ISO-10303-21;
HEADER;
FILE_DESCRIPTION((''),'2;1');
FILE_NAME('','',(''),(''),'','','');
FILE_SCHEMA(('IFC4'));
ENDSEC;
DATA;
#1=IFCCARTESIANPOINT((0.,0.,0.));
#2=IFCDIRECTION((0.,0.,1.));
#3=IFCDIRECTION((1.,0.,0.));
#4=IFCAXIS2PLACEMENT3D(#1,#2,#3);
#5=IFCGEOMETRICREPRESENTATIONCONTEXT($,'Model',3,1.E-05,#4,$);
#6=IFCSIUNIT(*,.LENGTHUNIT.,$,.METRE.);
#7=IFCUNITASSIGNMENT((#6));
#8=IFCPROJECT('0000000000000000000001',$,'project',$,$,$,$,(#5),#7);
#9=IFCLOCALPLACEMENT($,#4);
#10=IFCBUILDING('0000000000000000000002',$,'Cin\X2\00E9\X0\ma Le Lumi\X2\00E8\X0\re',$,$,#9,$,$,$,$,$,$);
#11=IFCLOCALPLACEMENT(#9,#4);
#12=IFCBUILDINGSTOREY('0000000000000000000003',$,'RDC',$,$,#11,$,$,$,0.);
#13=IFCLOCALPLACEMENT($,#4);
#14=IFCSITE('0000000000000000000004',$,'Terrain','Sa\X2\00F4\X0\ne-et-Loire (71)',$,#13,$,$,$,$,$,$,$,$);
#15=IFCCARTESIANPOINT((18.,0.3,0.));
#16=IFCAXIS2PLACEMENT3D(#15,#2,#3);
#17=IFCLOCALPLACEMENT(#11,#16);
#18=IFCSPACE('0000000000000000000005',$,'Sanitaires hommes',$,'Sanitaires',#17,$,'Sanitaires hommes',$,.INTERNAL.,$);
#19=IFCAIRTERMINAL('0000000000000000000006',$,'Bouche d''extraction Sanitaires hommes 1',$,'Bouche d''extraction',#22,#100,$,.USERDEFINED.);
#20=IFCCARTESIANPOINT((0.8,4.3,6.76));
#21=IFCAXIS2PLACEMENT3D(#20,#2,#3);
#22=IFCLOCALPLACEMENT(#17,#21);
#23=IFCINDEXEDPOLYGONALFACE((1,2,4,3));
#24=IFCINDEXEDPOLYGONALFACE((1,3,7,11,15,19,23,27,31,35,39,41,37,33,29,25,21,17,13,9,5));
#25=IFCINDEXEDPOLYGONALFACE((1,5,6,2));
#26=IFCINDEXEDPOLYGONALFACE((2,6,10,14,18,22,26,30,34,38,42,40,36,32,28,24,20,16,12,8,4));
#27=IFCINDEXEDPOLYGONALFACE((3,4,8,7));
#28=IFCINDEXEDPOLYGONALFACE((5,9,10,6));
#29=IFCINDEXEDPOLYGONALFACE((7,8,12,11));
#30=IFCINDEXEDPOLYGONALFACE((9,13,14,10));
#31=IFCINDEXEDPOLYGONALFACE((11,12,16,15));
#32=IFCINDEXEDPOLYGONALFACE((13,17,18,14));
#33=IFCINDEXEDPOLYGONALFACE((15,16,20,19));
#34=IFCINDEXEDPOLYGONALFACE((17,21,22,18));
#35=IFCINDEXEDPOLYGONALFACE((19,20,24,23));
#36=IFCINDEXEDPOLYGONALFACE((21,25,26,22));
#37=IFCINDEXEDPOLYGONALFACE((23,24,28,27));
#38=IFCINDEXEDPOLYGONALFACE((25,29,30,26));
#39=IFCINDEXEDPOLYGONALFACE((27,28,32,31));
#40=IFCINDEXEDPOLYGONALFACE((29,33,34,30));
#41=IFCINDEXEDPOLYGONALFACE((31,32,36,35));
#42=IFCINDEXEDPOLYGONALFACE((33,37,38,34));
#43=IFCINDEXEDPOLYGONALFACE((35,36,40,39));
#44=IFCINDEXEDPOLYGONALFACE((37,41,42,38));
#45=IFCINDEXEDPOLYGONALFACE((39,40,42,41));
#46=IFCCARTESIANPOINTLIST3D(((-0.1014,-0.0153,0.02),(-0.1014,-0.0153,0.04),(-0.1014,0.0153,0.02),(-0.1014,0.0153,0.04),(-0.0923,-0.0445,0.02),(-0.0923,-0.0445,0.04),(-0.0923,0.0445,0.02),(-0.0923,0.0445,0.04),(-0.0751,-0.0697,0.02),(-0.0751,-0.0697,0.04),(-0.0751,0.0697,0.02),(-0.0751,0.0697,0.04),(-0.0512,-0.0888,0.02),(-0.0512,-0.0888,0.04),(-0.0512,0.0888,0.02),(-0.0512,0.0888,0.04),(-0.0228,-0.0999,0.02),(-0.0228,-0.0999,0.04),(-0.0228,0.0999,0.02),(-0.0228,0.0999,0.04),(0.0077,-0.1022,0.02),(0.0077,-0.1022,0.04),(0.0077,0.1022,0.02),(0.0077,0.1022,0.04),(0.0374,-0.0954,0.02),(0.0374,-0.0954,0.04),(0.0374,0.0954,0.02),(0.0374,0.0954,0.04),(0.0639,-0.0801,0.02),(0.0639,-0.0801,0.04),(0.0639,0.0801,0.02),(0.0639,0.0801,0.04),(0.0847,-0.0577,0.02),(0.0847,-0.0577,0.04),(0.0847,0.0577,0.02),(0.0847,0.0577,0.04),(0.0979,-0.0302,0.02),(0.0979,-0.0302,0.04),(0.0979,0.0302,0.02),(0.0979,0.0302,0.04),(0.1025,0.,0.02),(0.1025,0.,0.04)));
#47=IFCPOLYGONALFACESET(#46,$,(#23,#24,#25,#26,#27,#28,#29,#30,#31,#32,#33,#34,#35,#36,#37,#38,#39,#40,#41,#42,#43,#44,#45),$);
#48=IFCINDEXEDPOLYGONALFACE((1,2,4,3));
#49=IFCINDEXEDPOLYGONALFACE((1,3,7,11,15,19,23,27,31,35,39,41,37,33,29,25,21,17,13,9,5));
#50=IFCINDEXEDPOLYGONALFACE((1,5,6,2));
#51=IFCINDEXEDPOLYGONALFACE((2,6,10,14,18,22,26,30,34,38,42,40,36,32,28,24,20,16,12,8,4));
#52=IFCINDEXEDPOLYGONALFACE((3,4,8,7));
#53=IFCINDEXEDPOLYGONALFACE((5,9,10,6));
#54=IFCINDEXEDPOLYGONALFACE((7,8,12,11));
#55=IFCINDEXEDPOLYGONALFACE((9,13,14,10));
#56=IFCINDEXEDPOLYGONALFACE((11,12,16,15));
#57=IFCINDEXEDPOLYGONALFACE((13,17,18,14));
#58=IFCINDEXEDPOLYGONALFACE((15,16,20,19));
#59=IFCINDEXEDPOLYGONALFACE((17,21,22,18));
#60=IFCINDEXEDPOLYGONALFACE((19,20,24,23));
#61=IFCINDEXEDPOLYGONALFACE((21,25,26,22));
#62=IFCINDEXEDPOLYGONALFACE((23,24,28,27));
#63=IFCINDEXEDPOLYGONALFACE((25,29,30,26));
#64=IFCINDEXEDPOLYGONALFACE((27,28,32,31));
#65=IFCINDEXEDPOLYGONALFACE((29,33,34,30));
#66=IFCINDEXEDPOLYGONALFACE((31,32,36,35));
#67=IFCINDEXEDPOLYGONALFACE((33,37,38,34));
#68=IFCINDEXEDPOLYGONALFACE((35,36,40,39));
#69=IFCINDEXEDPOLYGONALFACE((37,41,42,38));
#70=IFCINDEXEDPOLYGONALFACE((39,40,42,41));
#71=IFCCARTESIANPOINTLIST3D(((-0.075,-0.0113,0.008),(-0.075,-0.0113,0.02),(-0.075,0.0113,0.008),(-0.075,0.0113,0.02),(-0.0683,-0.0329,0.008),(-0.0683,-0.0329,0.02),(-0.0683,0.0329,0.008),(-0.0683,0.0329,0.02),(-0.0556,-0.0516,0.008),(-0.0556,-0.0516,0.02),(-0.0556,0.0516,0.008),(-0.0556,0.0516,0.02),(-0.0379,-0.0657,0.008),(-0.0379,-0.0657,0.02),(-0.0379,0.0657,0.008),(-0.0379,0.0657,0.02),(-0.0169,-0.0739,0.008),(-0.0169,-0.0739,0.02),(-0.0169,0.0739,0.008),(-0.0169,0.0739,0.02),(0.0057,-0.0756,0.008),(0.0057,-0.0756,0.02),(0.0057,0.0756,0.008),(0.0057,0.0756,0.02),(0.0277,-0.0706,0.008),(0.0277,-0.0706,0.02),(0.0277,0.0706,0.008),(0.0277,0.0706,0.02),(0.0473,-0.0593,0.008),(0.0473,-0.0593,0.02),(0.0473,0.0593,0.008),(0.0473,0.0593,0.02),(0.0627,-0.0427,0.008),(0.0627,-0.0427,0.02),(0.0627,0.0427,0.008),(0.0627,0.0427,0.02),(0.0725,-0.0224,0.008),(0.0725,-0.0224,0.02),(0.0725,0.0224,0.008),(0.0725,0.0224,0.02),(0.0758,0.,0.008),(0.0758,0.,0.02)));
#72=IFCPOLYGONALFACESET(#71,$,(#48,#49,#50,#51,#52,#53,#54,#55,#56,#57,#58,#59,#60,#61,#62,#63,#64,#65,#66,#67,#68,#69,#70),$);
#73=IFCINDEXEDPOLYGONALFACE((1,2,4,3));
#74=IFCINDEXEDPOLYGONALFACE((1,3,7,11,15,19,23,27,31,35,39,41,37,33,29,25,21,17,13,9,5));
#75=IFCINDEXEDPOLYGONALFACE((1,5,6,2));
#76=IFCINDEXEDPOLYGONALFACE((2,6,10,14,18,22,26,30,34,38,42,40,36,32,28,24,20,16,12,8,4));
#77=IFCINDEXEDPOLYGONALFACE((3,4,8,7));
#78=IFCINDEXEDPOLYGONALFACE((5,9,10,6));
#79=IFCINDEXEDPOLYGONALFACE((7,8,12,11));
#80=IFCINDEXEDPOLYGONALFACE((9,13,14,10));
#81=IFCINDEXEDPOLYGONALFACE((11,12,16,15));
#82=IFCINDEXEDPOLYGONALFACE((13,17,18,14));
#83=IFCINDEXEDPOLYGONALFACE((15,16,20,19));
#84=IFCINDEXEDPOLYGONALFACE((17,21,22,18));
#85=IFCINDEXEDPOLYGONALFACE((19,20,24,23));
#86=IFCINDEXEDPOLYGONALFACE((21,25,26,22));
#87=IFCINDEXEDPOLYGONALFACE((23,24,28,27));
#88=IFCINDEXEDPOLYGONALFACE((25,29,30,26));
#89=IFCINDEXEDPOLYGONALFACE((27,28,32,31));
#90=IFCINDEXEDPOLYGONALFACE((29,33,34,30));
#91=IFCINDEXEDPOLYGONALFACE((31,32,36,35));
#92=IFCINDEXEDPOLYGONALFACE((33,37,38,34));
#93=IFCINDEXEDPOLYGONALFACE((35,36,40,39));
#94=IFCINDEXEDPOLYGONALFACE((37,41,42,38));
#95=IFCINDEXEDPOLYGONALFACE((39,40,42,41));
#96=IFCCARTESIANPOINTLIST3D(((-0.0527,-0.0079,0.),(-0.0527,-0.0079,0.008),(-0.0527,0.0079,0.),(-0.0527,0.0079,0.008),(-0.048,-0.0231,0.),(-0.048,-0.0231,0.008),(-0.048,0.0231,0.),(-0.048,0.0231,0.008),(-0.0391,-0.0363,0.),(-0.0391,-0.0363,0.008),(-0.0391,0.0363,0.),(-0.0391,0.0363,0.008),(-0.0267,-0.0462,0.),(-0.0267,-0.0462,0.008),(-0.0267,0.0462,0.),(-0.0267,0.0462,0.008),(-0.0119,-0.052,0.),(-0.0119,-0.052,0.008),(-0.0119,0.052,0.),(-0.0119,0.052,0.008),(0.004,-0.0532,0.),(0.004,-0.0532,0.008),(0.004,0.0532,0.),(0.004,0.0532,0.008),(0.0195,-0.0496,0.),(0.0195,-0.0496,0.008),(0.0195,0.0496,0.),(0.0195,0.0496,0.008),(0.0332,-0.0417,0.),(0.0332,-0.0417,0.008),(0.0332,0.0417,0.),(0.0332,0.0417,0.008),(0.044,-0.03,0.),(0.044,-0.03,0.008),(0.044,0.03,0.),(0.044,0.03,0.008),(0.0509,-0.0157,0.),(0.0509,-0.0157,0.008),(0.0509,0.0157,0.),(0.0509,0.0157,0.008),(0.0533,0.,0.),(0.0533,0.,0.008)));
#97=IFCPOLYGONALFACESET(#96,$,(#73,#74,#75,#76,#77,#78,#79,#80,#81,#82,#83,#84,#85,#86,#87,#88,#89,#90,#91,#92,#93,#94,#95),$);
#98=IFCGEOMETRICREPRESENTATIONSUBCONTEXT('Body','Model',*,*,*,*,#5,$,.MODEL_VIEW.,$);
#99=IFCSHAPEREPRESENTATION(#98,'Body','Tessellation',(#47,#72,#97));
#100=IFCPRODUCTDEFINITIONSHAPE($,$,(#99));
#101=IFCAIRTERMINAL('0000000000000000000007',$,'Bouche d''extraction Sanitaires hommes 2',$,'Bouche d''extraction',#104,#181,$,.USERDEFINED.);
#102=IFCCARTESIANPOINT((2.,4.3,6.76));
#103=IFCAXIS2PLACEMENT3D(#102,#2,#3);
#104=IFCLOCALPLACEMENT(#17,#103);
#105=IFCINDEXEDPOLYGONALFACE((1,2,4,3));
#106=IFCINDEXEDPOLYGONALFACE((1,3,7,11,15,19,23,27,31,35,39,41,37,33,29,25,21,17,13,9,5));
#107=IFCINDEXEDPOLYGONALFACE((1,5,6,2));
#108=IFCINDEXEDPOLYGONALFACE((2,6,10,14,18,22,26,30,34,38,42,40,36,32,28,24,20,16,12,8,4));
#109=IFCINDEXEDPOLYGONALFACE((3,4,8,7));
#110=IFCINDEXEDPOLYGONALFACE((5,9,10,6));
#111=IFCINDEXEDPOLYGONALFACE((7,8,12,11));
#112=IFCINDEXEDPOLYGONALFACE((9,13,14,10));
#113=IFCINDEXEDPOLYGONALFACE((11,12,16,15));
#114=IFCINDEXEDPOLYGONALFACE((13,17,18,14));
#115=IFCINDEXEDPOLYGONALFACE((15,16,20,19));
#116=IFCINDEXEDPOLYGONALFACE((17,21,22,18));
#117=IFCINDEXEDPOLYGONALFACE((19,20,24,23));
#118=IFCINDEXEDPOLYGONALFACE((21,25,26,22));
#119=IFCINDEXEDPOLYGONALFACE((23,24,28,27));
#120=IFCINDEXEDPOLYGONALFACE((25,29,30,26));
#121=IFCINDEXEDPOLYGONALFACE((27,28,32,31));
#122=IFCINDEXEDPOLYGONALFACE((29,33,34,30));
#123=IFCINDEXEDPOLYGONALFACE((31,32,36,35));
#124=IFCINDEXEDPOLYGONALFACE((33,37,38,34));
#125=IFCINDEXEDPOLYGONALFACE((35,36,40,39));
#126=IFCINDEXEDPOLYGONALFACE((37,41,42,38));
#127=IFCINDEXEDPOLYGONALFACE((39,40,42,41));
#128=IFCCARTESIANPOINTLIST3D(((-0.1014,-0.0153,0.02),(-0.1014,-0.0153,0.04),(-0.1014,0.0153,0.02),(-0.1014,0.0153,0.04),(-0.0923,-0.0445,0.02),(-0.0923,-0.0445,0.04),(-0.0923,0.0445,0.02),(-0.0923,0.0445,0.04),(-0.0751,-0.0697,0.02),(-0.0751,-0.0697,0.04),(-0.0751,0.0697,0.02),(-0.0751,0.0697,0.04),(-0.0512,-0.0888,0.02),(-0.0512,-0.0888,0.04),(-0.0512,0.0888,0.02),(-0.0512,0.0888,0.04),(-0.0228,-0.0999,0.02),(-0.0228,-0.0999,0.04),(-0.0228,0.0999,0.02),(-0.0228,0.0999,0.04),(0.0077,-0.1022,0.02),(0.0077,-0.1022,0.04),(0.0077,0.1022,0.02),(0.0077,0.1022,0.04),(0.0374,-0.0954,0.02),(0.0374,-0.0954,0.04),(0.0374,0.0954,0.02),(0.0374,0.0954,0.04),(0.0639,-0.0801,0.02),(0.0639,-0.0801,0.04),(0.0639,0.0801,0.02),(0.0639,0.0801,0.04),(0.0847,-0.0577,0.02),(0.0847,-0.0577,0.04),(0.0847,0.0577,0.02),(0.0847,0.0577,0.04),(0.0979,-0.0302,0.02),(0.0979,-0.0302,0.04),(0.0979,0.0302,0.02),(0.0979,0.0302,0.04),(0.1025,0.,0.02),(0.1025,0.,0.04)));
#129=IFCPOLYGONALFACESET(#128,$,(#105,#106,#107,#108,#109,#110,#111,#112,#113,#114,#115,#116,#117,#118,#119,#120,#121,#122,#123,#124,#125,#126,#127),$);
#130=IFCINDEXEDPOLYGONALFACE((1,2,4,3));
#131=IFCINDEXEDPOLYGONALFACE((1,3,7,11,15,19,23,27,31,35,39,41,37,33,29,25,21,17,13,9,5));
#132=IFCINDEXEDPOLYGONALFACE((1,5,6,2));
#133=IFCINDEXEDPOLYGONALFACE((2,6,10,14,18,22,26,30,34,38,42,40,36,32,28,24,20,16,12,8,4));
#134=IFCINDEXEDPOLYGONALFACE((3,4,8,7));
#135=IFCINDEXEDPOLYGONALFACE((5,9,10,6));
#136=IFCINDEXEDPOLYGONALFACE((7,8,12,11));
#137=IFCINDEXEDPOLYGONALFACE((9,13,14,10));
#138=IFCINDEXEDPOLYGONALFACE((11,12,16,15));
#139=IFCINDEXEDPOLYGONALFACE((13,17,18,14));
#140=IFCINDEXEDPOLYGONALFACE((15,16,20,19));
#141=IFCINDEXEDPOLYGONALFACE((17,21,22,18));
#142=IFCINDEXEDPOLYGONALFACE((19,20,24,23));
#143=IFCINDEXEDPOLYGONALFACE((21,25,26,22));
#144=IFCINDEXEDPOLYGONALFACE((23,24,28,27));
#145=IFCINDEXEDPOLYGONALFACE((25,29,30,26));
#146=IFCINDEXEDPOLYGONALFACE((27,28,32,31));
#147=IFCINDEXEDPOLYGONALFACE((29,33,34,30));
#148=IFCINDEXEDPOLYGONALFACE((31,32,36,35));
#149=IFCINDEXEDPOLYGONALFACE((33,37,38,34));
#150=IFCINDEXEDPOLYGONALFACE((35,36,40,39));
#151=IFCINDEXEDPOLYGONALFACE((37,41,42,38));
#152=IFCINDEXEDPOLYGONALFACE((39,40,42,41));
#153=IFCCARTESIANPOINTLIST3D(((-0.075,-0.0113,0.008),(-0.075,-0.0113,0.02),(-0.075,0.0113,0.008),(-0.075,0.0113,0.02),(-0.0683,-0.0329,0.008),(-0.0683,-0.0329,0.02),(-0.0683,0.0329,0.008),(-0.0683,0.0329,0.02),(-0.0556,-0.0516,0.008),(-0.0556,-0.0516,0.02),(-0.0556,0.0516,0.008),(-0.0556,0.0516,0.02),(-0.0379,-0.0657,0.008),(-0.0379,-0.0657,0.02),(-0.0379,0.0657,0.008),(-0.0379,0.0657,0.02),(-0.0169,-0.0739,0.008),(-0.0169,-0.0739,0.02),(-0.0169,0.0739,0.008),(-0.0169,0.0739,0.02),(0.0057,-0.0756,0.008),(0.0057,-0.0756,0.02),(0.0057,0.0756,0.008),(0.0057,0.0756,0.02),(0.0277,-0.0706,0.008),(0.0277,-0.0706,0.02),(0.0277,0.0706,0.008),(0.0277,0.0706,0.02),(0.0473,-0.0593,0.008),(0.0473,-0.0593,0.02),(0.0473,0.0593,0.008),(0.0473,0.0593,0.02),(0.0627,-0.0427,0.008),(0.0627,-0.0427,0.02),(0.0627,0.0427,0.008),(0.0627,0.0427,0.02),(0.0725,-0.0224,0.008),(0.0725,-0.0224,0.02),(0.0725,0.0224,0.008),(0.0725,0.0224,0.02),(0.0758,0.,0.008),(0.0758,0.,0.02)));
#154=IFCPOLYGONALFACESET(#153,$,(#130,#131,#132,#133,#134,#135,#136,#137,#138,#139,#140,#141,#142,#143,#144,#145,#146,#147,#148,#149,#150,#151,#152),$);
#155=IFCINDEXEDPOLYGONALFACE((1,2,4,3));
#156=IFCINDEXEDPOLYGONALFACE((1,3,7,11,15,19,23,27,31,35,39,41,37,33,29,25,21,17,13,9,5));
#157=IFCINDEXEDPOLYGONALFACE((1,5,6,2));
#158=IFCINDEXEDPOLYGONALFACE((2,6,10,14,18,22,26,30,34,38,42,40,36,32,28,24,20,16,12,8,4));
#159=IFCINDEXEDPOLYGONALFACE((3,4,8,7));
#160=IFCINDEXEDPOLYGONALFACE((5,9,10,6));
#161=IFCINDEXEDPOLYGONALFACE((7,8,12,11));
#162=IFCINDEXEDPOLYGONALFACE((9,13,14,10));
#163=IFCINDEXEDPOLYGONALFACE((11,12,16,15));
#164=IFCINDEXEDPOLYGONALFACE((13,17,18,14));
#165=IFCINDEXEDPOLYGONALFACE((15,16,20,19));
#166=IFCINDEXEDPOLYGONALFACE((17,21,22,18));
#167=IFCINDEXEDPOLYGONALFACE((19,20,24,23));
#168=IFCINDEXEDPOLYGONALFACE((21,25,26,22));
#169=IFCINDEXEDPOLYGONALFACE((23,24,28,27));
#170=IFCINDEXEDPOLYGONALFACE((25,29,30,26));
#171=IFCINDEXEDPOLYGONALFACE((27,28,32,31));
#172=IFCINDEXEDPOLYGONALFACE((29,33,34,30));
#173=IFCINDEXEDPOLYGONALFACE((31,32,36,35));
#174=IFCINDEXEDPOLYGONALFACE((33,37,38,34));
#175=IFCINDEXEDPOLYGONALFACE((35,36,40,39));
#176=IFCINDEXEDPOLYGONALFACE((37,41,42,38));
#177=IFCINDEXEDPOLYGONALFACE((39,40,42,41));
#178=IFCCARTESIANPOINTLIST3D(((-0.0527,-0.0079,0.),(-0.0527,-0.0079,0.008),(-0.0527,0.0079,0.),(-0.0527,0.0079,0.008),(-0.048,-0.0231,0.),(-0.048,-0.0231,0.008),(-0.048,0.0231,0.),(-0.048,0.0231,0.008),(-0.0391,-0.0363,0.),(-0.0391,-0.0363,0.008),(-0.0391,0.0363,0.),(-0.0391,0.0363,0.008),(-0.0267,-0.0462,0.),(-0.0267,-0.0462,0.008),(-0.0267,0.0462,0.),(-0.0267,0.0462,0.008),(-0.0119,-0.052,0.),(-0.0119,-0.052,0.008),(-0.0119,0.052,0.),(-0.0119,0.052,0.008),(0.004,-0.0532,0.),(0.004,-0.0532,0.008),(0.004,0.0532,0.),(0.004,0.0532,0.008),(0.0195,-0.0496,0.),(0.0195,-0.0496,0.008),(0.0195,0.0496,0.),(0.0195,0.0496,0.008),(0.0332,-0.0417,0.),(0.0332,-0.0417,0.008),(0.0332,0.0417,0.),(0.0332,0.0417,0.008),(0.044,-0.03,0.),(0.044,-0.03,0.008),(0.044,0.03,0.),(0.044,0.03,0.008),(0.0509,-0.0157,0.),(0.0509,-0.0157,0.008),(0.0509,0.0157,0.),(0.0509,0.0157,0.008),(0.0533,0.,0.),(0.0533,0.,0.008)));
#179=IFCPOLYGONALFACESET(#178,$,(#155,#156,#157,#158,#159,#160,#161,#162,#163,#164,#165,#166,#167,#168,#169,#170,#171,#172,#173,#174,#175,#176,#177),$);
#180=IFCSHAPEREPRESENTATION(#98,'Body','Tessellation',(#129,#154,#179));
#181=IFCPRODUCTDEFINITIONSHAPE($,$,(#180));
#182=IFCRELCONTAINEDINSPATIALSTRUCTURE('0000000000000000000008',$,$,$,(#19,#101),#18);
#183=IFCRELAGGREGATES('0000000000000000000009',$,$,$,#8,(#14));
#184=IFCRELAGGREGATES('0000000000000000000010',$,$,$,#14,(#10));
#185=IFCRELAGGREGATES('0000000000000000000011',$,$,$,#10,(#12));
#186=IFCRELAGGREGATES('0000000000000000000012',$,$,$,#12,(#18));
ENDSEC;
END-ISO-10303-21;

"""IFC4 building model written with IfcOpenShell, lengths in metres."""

from ifc_helpers import new_model, si_unit, frame, origin_with_axes, place, context, subcontext, project, spatial, circle, extrude, element, save


model = new_model("IFC4")

# Units and contexts
model_context = context("Model", 3, precision=1e-05, world=origin_with_axes())
body_context = subcontext(model_context, "Body", "Model", "MODEL_VIEW")
ifc_project = project(units=[si_unit("LENGTHUNIT", "METRE")], contexts=[model_context])

# Site, building, storey
site_placement = place(None, origin_with_axes())
site = spatial("IfcSite", under=ifc_project, at=site_placement, Name="Terrain", Description="Saône-et-Loire (71)")
building_placement = place(None, origin_with_axes())
building = spatial("IfcBuilding", under=site, at=building_placement, Name="Cinéma Le Lumière")
storey_placement = place(building_placement, origin_with_axes())
storey = spatial("IfcBuildingStorey", under=building, at=storey_placement, Name="RDC", Elevation=0.0)

# Shared definitions
space_placement = place(storey_placement, frame((18.0, 0.3, 0.0), z_axis=(0.0, 0.0, 1.0), x_axis=(1.0, 0.0, 0.0)))
space = spatial("IfcSpace", under=storey, at=space_placement, Name="Sanitaires hommes", ObjectType="Sanitaires", LongName="Sanitaires hommes", PredefinedType="INTERNAL")

# Air terminal
air_terminal_1_placement = place(space_placement, frame((0.8, 4.3, 6.76), z_axis=(0.0, 0.0, 1.0), x_axis=(1.0, 0.0, 0.0)))
element("IfcAirTerminal", 1, at=air_terminal_1_placement, inside=space, Name="Bouche d'extraction Sanitaires hommes 1", ObjectType="Bouche d'extraction", PredefinedType="USERDEFINED", context=body_context, shape_type="SweptSolid", body=[
    extrude(circle(Radius=0.1025), frame((0.0, 0.0, 0.02), z_axis=(0.0, 0.0, 1.0), x_axis=(1.0, 0.0, 0.0)), (0.0, 0.0, 1.0), 0.02),
    extrude(circle(Radius=0.0759), frame((0.0, 0.0, 0.008), z_axis=(0.0, 0.0, 1.0), x_axis=(1.0, 0.0, 0.0)), (0.0, 0.0, 1.0), 0.012),
    extrude(circle(Radius=0.0533), origin_with_axes(), (0.0, 0.0, 1.0), 0.008),
])

# Air terminal
air_terminal_2_placement = place(space_placement, frame((2.0, 4.3, 6.76), z_axis=(0.0, 0.0, 1.0), x_axis=(1.0, 0.0, 0.0)))
element("IfcAirTerminal", 2, at=air_terminal_2_placement, inside=space, Name="Bouche d'extraction Sanitaires hommes 2", ObjectType="Bouche d'extraction", PredefinedType="USERDEFINED", context=body_context, shape_type="SweptSolid", body=[
    extrude(circle(Radius=0.1025), frame((0.0, 0.0, 0.02), z_axis=(0.0, 0.0, 1.0), x_axis=(1.0, 0.0, 0.0)), (0.0, 0.0, 1.0), 0.02),
    extrude(circle(Radius=0.0759), frame((0.0, 0.0, 0.008), z_axis=(0.0, 0.0, 1.0), x_axis=(1.0, 0.0, 0.0)), (0.0, 0.0, 1.0), 0.012),
    extrude(circle(Radius=0.0533), origin_with_axes(), (0.0, 0.0, 1.0), 0.008),
])

save(model, "model.ifc")
